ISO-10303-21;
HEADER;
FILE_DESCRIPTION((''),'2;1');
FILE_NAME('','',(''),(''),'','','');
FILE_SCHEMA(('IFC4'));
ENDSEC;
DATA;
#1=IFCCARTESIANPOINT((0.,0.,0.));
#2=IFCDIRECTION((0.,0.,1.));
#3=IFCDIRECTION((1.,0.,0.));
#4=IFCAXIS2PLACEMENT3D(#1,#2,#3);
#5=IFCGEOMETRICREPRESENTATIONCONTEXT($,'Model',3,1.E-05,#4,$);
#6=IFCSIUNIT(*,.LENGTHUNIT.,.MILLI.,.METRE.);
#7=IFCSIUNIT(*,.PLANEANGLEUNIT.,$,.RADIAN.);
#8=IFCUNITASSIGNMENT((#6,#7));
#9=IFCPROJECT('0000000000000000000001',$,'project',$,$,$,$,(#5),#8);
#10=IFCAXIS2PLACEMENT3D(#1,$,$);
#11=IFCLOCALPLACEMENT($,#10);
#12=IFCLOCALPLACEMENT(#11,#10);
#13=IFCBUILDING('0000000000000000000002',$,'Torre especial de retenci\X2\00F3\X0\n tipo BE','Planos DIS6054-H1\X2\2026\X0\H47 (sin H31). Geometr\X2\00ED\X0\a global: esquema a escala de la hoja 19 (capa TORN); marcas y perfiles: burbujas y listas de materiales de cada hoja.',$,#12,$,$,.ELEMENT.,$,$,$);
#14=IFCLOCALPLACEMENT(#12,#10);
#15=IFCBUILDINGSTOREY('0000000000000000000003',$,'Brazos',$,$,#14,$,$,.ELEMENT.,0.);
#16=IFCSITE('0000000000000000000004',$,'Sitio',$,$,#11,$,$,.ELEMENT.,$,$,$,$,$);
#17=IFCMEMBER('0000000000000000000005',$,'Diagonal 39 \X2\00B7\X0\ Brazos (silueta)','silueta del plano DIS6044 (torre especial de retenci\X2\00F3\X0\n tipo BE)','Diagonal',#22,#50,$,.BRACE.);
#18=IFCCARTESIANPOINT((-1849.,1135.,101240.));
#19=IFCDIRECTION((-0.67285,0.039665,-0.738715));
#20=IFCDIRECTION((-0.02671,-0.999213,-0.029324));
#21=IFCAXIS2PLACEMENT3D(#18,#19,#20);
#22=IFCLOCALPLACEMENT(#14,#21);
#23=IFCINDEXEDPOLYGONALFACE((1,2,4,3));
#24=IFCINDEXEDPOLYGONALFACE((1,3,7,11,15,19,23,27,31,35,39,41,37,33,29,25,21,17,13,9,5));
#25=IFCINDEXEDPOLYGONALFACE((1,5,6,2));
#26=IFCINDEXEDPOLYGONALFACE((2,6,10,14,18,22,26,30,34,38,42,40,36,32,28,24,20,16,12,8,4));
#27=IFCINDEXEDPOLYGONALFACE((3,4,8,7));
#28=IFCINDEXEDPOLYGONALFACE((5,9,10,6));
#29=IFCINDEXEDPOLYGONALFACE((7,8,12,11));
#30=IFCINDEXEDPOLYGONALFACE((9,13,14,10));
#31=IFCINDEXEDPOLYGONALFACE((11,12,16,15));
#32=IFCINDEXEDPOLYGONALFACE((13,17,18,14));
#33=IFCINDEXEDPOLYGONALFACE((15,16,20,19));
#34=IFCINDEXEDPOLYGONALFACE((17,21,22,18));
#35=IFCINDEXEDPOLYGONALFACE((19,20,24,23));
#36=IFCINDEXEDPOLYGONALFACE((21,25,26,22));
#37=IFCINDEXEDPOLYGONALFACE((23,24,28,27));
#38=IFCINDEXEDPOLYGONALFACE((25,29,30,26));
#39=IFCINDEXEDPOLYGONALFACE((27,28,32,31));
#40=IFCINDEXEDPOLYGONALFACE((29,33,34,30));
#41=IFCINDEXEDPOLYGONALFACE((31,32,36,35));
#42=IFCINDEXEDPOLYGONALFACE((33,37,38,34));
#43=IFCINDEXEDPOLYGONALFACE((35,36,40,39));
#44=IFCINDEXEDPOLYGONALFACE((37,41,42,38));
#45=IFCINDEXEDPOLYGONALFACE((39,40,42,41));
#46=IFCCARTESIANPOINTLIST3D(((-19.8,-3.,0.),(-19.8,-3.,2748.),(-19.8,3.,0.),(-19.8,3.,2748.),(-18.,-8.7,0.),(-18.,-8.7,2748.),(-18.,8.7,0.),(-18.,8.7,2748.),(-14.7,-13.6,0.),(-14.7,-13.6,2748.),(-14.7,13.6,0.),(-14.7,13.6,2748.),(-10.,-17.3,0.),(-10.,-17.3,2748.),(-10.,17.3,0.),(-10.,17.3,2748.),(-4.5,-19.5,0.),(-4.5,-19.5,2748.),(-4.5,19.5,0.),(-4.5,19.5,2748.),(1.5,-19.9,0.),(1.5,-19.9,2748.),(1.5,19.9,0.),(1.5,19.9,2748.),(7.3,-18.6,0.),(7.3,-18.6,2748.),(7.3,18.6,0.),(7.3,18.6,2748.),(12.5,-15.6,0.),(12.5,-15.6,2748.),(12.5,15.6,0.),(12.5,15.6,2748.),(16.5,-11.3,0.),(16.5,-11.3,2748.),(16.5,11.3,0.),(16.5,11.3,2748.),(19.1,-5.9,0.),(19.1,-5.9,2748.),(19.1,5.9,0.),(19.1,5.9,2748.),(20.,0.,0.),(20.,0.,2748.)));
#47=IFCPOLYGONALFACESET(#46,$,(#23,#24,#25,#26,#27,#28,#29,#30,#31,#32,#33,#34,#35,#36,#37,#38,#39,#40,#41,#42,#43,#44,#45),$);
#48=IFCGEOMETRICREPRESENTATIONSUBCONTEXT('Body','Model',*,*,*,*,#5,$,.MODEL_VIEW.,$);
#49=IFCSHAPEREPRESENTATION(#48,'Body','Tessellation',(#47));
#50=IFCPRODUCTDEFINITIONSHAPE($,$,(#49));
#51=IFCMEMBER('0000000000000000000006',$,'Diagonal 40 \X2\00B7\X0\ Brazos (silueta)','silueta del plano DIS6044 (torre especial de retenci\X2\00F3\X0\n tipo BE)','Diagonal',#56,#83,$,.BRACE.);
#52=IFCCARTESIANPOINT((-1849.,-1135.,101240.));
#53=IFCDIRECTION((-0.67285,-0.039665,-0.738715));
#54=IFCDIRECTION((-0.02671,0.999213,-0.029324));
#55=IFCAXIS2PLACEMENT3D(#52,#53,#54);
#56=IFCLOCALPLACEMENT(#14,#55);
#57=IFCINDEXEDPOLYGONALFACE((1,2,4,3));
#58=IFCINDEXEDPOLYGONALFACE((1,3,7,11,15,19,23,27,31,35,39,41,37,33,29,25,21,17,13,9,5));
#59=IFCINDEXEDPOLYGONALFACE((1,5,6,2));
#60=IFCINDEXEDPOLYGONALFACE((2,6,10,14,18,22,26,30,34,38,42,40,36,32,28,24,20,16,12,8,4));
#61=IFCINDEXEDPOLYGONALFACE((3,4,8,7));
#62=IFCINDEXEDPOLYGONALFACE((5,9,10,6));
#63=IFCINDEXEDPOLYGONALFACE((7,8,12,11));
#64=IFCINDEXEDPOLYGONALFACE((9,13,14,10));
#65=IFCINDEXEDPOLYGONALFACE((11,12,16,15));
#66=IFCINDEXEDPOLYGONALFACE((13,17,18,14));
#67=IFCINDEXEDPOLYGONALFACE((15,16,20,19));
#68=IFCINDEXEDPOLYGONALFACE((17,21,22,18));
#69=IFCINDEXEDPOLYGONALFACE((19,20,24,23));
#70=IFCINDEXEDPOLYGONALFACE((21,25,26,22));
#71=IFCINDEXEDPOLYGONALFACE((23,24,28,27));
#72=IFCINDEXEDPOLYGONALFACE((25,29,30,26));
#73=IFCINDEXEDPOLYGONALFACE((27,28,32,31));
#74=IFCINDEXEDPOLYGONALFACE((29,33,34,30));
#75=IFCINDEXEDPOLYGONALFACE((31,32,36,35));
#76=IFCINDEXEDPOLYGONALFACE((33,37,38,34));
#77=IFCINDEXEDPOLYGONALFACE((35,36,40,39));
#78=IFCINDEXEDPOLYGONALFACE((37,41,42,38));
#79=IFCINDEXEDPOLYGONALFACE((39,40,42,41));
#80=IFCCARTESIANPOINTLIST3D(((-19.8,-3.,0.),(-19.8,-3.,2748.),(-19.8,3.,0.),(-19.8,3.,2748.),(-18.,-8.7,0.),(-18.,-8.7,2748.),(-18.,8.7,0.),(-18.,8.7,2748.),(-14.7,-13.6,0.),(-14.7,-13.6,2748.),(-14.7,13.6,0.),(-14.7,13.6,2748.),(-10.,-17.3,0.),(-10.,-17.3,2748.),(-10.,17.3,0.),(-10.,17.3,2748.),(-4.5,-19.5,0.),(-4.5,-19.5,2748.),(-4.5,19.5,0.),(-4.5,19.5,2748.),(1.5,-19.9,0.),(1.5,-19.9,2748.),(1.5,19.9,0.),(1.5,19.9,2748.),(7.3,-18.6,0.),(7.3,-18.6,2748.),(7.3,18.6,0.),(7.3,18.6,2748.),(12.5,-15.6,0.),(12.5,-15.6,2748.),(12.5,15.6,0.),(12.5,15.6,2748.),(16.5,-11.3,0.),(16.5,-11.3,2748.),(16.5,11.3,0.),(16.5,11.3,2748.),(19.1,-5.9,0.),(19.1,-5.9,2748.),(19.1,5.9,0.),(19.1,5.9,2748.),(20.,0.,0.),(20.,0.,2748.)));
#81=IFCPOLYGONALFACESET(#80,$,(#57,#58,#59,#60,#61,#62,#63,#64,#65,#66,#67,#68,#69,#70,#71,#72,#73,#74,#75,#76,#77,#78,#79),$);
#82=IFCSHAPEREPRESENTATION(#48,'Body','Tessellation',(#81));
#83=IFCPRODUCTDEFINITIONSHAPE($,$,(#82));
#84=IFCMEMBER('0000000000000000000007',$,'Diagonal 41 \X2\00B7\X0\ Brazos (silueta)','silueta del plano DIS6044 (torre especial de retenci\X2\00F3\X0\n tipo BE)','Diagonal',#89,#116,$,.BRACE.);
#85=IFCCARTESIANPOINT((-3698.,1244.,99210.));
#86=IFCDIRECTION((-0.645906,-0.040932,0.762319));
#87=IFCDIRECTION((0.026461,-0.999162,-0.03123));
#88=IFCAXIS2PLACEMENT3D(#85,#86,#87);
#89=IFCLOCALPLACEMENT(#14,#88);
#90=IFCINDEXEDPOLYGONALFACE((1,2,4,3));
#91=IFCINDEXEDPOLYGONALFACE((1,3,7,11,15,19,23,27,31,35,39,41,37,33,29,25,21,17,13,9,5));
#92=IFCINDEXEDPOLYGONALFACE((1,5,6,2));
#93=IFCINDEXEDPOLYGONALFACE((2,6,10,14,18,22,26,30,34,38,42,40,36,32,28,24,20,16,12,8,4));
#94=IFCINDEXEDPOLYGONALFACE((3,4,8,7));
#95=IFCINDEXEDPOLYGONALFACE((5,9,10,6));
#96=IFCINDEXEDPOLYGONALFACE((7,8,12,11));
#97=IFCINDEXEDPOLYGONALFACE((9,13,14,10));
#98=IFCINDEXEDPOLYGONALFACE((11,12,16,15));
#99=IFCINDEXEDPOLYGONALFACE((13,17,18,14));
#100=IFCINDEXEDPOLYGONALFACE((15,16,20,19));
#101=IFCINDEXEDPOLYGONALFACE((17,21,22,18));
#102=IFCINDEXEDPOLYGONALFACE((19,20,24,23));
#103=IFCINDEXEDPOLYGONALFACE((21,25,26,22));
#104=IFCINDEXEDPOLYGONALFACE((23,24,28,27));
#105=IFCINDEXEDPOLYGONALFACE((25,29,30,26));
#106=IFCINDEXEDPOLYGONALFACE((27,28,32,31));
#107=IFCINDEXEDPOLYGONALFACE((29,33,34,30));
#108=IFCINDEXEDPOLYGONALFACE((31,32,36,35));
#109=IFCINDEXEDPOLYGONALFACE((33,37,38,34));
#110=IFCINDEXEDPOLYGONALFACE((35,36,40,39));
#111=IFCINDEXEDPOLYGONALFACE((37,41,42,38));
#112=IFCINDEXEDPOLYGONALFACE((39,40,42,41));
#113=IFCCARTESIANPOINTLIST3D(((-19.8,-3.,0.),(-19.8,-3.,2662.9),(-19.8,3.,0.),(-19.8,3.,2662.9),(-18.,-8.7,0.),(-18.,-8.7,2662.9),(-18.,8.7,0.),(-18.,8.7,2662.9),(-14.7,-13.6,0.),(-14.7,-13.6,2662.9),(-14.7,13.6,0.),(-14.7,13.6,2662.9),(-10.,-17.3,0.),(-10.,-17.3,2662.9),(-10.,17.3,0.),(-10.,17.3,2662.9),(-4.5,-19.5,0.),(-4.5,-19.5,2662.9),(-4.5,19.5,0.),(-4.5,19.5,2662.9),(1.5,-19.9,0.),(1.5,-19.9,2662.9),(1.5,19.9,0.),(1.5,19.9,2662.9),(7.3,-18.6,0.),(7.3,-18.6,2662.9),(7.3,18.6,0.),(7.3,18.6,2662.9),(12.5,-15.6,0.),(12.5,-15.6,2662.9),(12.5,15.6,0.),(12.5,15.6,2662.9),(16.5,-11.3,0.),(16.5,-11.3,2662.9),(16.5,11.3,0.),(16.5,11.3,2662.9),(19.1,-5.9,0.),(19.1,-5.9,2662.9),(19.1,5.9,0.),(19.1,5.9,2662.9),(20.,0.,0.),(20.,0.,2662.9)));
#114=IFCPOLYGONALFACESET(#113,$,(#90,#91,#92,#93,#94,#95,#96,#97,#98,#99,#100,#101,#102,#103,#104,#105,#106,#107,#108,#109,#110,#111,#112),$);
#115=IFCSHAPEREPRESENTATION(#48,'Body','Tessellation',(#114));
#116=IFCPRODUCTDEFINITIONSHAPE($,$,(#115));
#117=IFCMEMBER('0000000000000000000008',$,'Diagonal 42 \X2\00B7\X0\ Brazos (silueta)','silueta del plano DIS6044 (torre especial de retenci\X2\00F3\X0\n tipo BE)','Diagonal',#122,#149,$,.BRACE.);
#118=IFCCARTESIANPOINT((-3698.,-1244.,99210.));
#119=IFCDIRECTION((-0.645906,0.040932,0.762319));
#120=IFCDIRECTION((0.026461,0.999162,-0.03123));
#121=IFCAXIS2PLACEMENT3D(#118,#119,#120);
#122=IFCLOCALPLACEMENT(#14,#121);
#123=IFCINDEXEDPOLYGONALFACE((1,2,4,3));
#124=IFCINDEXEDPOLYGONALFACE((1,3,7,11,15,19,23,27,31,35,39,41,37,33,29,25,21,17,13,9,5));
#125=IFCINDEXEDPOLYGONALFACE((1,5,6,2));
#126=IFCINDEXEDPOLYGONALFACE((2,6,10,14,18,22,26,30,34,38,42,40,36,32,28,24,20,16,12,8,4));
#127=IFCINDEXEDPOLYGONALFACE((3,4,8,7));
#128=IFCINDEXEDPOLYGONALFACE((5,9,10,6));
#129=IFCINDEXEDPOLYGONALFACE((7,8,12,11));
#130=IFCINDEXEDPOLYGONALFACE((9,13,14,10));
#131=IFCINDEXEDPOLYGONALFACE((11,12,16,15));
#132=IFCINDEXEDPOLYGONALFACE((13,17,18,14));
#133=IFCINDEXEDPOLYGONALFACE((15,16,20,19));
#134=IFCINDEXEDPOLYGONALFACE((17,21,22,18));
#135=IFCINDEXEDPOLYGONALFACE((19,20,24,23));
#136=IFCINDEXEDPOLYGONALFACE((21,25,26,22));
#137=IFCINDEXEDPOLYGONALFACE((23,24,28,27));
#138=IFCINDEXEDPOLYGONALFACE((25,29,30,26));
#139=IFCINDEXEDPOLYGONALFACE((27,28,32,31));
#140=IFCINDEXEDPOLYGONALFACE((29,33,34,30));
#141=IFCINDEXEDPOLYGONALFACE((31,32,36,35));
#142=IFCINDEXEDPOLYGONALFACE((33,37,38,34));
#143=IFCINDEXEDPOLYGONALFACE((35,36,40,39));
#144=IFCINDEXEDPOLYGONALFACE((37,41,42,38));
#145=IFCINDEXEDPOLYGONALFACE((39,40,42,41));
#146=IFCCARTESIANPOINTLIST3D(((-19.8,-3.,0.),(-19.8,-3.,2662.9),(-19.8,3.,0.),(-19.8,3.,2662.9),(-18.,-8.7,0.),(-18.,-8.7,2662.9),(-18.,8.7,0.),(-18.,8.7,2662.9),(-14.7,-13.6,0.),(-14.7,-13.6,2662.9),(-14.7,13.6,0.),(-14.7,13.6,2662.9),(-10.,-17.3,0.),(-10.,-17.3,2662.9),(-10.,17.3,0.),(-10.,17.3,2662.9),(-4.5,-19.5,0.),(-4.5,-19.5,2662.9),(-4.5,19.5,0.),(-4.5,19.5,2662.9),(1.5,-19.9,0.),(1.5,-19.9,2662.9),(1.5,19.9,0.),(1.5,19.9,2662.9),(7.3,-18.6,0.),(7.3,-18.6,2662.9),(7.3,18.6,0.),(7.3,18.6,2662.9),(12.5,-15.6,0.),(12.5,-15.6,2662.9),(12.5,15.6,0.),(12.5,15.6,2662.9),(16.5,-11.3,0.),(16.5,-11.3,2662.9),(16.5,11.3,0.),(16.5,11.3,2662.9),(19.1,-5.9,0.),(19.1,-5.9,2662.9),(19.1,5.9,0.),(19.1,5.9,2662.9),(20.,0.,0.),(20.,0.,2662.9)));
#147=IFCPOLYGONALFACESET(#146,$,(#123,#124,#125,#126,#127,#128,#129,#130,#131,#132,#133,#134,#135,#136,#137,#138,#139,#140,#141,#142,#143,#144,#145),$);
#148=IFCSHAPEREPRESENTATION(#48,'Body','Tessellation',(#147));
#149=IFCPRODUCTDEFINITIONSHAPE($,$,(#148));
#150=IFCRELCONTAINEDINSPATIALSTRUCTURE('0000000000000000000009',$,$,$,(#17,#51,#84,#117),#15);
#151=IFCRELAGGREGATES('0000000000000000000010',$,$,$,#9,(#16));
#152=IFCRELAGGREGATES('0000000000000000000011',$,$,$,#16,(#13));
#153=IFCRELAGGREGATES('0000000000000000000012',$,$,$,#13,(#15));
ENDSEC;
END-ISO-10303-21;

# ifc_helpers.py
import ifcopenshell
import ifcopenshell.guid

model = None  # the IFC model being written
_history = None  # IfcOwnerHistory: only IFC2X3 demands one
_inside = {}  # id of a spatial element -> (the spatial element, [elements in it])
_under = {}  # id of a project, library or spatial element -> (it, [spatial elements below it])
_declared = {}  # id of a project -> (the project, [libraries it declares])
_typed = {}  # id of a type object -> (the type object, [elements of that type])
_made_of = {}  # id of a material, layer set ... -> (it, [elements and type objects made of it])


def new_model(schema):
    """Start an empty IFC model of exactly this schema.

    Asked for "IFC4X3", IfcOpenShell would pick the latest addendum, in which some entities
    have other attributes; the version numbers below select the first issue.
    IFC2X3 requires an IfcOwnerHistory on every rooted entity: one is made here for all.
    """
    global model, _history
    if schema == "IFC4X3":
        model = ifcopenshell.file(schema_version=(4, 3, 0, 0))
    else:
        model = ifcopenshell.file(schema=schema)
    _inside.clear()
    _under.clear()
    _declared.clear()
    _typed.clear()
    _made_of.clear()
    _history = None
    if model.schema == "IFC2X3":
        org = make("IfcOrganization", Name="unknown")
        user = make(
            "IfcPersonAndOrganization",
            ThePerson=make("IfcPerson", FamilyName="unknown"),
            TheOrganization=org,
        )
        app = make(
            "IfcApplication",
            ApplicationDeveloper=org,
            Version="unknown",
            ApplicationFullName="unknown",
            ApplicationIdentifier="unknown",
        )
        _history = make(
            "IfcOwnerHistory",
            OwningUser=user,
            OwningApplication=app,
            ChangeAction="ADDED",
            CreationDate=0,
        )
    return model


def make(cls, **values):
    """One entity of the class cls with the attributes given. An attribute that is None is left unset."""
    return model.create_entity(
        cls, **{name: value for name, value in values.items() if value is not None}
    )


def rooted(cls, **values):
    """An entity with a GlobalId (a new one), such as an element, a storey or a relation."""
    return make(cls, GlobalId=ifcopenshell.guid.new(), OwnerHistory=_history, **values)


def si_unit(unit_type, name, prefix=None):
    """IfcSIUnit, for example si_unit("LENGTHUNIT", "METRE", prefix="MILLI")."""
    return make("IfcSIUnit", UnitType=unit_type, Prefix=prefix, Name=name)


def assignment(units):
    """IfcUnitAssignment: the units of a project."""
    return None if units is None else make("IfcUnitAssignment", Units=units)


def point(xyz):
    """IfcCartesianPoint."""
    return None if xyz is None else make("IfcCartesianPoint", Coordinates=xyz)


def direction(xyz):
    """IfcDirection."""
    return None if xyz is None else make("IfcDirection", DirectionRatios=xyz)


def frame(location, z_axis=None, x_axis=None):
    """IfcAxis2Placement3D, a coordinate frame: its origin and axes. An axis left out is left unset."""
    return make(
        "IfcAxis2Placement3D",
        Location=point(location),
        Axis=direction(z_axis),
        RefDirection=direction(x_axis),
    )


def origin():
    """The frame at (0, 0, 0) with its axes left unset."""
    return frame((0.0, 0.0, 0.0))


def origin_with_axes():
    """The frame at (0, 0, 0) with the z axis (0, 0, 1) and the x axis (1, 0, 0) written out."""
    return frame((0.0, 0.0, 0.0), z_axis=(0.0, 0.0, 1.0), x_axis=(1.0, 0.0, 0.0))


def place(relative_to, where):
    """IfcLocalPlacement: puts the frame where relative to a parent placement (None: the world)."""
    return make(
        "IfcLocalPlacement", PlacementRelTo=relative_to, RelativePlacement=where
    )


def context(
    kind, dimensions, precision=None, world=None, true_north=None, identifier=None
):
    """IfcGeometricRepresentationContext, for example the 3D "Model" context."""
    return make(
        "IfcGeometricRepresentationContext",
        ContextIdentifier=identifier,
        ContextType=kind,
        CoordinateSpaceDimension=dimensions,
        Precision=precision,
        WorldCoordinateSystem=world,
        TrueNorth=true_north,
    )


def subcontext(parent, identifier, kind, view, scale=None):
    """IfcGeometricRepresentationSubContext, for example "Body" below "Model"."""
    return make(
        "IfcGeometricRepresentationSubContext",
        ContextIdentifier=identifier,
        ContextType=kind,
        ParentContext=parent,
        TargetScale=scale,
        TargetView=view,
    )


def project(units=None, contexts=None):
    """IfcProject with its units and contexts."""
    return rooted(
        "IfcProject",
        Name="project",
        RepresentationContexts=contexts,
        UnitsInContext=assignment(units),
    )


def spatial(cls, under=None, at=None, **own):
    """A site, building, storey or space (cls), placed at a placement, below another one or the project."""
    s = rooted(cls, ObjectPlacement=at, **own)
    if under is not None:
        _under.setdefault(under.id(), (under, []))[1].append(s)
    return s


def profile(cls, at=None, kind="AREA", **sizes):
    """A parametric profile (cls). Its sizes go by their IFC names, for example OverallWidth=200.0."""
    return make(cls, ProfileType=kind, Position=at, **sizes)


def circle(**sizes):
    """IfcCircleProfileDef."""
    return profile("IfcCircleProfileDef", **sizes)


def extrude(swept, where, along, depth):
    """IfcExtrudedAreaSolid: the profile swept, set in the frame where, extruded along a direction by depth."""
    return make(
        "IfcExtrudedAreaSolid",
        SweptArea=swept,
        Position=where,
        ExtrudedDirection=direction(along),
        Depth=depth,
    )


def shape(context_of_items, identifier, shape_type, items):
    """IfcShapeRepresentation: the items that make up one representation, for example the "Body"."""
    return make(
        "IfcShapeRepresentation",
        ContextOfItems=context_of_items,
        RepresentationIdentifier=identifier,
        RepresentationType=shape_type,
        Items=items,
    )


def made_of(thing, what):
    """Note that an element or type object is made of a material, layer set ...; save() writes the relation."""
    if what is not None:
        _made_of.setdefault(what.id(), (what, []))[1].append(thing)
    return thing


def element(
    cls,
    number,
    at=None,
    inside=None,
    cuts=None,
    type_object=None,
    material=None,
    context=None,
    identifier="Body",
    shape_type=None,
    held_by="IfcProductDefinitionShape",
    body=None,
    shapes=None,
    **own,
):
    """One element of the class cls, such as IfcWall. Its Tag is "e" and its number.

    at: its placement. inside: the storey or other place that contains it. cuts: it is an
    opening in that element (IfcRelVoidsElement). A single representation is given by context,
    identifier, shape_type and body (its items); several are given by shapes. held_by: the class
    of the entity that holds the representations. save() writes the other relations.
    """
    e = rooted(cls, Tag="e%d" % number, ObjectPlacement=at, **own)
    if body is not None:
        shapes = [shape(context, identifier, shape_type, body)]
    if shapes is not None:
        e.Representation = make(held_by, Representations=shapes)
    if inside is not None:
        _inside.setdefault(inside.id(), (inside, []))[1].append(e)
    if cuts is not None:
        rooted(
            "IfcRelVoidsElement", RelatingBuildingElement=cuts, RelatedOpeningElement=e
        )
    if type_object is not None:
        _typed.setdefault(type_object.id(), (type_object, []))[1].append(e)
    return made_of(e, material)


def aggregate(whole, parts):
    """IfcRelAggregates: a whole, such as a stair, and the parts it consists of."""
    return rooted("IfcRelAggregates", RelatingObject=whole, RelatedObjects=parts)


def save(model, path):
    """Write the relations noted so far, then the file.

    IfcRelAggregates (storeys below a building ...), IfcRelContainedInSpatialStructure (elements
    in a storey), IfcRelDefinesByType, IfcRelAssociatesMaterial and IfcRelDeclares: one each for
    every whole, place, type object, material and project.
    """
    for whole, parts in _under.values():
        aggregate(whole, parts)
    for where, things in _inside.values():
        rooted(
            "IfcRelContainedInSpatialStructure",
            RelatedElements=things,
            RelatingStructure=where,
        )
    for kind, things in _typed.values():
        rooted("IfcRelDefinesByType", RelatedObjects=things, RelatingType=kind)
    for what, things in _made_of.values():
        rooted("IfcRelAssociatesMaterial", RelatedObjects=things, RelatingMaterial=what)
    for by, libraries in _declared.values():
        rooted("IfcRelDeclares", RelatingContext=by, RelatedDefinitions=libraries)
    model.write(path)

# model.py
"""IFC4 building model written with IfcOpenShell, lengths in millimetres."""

from ifc_helpers import new_model, si_unit, frame, origin, origin_with_axes, place, context, subcontext, project, spatial, circle, extrude, element, save


model = new_model("IFC4")

# Units and contexts
model_context = context("Model", 3, precision=1e-05, world=origin_with_axes())
body_context = subcontext(model_context, "Body", "Model", "MODEL_VIEW")
ifc_project = project(units=[si_unit("LENGTHUNIT", "METRE", prefix="MILLI"), si_unit("PLANEANGLEUNIT", "RADIAN")], contexts=[model_context])

# Site, building, storey
site_placement = place(None, origin())
site = spatial("IfcSite", under=ifc_project, at=site_placement, Name="Sitio", CompositionType="ELEMENT")
building_placement = place(site_placement, origin())
building = spatial("IfcBuilding", under=site, at=building_placement, Name="Torre especial de retención tipo BE", Description="Planos DIS6054-H1…H47 (sin H31). Geometría global: esquema a escala de la hoja 19 (capa TORN); marcas y perfiles: burbujas y listas de materiales de cada hoja.", CompositionType="ELEMENT")
storey_placement = place(building_placement, origin())
storey = spatial("IfcBuildingStorey", under=building, at=storey_placement, Name="Brazos", CompositionType="ELEMENT", Elevation=0.0)

# Members
for number, where, z_axis, x_axis, name in (
    (1, (-1849.0, 1135.0, 101240.0), (-0.67285, 0.039665, -0.738715), (-0.02671, -0.999213, -0.029324), "Diagonal 39 · Brazos (silueta)"),
    (2, (-1849.0, -1135.0, 101240.0), (-0.67285, -0.039665, -0.738715), (-0.02671, 0.999213, -0.029324), "Diagonal 40 · Brazos (silueta)"),
):
    element("IfcMember", number, at=place(storey_placement, frame(where, z_axis=z_axis, x_axis=x_axis)), inside=storey, Name=name, Description="silueta del plano DIS6044 (torre especial de retención tipo BE)", ObjectType="Diagonal", PredefinedType="BRACE", context=body_context, shape_type="SweptSolid", body=[
        extrude(circle(Radius=20.0), None, (0.0, 0.0, 1.0), 2748.0),
    ])
for number, where, z_axis, x_axis, name in (
    (3, (-3698.0, 1244.0, 99210.0), (-0.645906, -0.040932, 0.762319), (0.026461, -0.999162, -0.03123), "Diagonal 41 · Brazos (silueta)"),
    (4, (-3698.0, -1244.0, 99210.0), (-0.645906, 0.040932, 0.762319), (0.026461, 0.999162, -0.03123), "Diagonal 42 · Brazos (silueta)"),
):
    element("IfcMember", number, at=place(storey_placement, frame(where, z_axis=z_axis, x_axis=x_axis)), inside=storey, Name=name, Description="silueta del plano DIS6044 (torre especial de retención tipo BE)", ObjectType="Diagonal", PredefinedType="BRACE", context=body_context, shape_type="SweptSolid", body=[
        extrude(circle(Radius=20.0), None, (0.0, 0.0, 1.0), 2662.9),
    ])

save(model, "model.ifc")
